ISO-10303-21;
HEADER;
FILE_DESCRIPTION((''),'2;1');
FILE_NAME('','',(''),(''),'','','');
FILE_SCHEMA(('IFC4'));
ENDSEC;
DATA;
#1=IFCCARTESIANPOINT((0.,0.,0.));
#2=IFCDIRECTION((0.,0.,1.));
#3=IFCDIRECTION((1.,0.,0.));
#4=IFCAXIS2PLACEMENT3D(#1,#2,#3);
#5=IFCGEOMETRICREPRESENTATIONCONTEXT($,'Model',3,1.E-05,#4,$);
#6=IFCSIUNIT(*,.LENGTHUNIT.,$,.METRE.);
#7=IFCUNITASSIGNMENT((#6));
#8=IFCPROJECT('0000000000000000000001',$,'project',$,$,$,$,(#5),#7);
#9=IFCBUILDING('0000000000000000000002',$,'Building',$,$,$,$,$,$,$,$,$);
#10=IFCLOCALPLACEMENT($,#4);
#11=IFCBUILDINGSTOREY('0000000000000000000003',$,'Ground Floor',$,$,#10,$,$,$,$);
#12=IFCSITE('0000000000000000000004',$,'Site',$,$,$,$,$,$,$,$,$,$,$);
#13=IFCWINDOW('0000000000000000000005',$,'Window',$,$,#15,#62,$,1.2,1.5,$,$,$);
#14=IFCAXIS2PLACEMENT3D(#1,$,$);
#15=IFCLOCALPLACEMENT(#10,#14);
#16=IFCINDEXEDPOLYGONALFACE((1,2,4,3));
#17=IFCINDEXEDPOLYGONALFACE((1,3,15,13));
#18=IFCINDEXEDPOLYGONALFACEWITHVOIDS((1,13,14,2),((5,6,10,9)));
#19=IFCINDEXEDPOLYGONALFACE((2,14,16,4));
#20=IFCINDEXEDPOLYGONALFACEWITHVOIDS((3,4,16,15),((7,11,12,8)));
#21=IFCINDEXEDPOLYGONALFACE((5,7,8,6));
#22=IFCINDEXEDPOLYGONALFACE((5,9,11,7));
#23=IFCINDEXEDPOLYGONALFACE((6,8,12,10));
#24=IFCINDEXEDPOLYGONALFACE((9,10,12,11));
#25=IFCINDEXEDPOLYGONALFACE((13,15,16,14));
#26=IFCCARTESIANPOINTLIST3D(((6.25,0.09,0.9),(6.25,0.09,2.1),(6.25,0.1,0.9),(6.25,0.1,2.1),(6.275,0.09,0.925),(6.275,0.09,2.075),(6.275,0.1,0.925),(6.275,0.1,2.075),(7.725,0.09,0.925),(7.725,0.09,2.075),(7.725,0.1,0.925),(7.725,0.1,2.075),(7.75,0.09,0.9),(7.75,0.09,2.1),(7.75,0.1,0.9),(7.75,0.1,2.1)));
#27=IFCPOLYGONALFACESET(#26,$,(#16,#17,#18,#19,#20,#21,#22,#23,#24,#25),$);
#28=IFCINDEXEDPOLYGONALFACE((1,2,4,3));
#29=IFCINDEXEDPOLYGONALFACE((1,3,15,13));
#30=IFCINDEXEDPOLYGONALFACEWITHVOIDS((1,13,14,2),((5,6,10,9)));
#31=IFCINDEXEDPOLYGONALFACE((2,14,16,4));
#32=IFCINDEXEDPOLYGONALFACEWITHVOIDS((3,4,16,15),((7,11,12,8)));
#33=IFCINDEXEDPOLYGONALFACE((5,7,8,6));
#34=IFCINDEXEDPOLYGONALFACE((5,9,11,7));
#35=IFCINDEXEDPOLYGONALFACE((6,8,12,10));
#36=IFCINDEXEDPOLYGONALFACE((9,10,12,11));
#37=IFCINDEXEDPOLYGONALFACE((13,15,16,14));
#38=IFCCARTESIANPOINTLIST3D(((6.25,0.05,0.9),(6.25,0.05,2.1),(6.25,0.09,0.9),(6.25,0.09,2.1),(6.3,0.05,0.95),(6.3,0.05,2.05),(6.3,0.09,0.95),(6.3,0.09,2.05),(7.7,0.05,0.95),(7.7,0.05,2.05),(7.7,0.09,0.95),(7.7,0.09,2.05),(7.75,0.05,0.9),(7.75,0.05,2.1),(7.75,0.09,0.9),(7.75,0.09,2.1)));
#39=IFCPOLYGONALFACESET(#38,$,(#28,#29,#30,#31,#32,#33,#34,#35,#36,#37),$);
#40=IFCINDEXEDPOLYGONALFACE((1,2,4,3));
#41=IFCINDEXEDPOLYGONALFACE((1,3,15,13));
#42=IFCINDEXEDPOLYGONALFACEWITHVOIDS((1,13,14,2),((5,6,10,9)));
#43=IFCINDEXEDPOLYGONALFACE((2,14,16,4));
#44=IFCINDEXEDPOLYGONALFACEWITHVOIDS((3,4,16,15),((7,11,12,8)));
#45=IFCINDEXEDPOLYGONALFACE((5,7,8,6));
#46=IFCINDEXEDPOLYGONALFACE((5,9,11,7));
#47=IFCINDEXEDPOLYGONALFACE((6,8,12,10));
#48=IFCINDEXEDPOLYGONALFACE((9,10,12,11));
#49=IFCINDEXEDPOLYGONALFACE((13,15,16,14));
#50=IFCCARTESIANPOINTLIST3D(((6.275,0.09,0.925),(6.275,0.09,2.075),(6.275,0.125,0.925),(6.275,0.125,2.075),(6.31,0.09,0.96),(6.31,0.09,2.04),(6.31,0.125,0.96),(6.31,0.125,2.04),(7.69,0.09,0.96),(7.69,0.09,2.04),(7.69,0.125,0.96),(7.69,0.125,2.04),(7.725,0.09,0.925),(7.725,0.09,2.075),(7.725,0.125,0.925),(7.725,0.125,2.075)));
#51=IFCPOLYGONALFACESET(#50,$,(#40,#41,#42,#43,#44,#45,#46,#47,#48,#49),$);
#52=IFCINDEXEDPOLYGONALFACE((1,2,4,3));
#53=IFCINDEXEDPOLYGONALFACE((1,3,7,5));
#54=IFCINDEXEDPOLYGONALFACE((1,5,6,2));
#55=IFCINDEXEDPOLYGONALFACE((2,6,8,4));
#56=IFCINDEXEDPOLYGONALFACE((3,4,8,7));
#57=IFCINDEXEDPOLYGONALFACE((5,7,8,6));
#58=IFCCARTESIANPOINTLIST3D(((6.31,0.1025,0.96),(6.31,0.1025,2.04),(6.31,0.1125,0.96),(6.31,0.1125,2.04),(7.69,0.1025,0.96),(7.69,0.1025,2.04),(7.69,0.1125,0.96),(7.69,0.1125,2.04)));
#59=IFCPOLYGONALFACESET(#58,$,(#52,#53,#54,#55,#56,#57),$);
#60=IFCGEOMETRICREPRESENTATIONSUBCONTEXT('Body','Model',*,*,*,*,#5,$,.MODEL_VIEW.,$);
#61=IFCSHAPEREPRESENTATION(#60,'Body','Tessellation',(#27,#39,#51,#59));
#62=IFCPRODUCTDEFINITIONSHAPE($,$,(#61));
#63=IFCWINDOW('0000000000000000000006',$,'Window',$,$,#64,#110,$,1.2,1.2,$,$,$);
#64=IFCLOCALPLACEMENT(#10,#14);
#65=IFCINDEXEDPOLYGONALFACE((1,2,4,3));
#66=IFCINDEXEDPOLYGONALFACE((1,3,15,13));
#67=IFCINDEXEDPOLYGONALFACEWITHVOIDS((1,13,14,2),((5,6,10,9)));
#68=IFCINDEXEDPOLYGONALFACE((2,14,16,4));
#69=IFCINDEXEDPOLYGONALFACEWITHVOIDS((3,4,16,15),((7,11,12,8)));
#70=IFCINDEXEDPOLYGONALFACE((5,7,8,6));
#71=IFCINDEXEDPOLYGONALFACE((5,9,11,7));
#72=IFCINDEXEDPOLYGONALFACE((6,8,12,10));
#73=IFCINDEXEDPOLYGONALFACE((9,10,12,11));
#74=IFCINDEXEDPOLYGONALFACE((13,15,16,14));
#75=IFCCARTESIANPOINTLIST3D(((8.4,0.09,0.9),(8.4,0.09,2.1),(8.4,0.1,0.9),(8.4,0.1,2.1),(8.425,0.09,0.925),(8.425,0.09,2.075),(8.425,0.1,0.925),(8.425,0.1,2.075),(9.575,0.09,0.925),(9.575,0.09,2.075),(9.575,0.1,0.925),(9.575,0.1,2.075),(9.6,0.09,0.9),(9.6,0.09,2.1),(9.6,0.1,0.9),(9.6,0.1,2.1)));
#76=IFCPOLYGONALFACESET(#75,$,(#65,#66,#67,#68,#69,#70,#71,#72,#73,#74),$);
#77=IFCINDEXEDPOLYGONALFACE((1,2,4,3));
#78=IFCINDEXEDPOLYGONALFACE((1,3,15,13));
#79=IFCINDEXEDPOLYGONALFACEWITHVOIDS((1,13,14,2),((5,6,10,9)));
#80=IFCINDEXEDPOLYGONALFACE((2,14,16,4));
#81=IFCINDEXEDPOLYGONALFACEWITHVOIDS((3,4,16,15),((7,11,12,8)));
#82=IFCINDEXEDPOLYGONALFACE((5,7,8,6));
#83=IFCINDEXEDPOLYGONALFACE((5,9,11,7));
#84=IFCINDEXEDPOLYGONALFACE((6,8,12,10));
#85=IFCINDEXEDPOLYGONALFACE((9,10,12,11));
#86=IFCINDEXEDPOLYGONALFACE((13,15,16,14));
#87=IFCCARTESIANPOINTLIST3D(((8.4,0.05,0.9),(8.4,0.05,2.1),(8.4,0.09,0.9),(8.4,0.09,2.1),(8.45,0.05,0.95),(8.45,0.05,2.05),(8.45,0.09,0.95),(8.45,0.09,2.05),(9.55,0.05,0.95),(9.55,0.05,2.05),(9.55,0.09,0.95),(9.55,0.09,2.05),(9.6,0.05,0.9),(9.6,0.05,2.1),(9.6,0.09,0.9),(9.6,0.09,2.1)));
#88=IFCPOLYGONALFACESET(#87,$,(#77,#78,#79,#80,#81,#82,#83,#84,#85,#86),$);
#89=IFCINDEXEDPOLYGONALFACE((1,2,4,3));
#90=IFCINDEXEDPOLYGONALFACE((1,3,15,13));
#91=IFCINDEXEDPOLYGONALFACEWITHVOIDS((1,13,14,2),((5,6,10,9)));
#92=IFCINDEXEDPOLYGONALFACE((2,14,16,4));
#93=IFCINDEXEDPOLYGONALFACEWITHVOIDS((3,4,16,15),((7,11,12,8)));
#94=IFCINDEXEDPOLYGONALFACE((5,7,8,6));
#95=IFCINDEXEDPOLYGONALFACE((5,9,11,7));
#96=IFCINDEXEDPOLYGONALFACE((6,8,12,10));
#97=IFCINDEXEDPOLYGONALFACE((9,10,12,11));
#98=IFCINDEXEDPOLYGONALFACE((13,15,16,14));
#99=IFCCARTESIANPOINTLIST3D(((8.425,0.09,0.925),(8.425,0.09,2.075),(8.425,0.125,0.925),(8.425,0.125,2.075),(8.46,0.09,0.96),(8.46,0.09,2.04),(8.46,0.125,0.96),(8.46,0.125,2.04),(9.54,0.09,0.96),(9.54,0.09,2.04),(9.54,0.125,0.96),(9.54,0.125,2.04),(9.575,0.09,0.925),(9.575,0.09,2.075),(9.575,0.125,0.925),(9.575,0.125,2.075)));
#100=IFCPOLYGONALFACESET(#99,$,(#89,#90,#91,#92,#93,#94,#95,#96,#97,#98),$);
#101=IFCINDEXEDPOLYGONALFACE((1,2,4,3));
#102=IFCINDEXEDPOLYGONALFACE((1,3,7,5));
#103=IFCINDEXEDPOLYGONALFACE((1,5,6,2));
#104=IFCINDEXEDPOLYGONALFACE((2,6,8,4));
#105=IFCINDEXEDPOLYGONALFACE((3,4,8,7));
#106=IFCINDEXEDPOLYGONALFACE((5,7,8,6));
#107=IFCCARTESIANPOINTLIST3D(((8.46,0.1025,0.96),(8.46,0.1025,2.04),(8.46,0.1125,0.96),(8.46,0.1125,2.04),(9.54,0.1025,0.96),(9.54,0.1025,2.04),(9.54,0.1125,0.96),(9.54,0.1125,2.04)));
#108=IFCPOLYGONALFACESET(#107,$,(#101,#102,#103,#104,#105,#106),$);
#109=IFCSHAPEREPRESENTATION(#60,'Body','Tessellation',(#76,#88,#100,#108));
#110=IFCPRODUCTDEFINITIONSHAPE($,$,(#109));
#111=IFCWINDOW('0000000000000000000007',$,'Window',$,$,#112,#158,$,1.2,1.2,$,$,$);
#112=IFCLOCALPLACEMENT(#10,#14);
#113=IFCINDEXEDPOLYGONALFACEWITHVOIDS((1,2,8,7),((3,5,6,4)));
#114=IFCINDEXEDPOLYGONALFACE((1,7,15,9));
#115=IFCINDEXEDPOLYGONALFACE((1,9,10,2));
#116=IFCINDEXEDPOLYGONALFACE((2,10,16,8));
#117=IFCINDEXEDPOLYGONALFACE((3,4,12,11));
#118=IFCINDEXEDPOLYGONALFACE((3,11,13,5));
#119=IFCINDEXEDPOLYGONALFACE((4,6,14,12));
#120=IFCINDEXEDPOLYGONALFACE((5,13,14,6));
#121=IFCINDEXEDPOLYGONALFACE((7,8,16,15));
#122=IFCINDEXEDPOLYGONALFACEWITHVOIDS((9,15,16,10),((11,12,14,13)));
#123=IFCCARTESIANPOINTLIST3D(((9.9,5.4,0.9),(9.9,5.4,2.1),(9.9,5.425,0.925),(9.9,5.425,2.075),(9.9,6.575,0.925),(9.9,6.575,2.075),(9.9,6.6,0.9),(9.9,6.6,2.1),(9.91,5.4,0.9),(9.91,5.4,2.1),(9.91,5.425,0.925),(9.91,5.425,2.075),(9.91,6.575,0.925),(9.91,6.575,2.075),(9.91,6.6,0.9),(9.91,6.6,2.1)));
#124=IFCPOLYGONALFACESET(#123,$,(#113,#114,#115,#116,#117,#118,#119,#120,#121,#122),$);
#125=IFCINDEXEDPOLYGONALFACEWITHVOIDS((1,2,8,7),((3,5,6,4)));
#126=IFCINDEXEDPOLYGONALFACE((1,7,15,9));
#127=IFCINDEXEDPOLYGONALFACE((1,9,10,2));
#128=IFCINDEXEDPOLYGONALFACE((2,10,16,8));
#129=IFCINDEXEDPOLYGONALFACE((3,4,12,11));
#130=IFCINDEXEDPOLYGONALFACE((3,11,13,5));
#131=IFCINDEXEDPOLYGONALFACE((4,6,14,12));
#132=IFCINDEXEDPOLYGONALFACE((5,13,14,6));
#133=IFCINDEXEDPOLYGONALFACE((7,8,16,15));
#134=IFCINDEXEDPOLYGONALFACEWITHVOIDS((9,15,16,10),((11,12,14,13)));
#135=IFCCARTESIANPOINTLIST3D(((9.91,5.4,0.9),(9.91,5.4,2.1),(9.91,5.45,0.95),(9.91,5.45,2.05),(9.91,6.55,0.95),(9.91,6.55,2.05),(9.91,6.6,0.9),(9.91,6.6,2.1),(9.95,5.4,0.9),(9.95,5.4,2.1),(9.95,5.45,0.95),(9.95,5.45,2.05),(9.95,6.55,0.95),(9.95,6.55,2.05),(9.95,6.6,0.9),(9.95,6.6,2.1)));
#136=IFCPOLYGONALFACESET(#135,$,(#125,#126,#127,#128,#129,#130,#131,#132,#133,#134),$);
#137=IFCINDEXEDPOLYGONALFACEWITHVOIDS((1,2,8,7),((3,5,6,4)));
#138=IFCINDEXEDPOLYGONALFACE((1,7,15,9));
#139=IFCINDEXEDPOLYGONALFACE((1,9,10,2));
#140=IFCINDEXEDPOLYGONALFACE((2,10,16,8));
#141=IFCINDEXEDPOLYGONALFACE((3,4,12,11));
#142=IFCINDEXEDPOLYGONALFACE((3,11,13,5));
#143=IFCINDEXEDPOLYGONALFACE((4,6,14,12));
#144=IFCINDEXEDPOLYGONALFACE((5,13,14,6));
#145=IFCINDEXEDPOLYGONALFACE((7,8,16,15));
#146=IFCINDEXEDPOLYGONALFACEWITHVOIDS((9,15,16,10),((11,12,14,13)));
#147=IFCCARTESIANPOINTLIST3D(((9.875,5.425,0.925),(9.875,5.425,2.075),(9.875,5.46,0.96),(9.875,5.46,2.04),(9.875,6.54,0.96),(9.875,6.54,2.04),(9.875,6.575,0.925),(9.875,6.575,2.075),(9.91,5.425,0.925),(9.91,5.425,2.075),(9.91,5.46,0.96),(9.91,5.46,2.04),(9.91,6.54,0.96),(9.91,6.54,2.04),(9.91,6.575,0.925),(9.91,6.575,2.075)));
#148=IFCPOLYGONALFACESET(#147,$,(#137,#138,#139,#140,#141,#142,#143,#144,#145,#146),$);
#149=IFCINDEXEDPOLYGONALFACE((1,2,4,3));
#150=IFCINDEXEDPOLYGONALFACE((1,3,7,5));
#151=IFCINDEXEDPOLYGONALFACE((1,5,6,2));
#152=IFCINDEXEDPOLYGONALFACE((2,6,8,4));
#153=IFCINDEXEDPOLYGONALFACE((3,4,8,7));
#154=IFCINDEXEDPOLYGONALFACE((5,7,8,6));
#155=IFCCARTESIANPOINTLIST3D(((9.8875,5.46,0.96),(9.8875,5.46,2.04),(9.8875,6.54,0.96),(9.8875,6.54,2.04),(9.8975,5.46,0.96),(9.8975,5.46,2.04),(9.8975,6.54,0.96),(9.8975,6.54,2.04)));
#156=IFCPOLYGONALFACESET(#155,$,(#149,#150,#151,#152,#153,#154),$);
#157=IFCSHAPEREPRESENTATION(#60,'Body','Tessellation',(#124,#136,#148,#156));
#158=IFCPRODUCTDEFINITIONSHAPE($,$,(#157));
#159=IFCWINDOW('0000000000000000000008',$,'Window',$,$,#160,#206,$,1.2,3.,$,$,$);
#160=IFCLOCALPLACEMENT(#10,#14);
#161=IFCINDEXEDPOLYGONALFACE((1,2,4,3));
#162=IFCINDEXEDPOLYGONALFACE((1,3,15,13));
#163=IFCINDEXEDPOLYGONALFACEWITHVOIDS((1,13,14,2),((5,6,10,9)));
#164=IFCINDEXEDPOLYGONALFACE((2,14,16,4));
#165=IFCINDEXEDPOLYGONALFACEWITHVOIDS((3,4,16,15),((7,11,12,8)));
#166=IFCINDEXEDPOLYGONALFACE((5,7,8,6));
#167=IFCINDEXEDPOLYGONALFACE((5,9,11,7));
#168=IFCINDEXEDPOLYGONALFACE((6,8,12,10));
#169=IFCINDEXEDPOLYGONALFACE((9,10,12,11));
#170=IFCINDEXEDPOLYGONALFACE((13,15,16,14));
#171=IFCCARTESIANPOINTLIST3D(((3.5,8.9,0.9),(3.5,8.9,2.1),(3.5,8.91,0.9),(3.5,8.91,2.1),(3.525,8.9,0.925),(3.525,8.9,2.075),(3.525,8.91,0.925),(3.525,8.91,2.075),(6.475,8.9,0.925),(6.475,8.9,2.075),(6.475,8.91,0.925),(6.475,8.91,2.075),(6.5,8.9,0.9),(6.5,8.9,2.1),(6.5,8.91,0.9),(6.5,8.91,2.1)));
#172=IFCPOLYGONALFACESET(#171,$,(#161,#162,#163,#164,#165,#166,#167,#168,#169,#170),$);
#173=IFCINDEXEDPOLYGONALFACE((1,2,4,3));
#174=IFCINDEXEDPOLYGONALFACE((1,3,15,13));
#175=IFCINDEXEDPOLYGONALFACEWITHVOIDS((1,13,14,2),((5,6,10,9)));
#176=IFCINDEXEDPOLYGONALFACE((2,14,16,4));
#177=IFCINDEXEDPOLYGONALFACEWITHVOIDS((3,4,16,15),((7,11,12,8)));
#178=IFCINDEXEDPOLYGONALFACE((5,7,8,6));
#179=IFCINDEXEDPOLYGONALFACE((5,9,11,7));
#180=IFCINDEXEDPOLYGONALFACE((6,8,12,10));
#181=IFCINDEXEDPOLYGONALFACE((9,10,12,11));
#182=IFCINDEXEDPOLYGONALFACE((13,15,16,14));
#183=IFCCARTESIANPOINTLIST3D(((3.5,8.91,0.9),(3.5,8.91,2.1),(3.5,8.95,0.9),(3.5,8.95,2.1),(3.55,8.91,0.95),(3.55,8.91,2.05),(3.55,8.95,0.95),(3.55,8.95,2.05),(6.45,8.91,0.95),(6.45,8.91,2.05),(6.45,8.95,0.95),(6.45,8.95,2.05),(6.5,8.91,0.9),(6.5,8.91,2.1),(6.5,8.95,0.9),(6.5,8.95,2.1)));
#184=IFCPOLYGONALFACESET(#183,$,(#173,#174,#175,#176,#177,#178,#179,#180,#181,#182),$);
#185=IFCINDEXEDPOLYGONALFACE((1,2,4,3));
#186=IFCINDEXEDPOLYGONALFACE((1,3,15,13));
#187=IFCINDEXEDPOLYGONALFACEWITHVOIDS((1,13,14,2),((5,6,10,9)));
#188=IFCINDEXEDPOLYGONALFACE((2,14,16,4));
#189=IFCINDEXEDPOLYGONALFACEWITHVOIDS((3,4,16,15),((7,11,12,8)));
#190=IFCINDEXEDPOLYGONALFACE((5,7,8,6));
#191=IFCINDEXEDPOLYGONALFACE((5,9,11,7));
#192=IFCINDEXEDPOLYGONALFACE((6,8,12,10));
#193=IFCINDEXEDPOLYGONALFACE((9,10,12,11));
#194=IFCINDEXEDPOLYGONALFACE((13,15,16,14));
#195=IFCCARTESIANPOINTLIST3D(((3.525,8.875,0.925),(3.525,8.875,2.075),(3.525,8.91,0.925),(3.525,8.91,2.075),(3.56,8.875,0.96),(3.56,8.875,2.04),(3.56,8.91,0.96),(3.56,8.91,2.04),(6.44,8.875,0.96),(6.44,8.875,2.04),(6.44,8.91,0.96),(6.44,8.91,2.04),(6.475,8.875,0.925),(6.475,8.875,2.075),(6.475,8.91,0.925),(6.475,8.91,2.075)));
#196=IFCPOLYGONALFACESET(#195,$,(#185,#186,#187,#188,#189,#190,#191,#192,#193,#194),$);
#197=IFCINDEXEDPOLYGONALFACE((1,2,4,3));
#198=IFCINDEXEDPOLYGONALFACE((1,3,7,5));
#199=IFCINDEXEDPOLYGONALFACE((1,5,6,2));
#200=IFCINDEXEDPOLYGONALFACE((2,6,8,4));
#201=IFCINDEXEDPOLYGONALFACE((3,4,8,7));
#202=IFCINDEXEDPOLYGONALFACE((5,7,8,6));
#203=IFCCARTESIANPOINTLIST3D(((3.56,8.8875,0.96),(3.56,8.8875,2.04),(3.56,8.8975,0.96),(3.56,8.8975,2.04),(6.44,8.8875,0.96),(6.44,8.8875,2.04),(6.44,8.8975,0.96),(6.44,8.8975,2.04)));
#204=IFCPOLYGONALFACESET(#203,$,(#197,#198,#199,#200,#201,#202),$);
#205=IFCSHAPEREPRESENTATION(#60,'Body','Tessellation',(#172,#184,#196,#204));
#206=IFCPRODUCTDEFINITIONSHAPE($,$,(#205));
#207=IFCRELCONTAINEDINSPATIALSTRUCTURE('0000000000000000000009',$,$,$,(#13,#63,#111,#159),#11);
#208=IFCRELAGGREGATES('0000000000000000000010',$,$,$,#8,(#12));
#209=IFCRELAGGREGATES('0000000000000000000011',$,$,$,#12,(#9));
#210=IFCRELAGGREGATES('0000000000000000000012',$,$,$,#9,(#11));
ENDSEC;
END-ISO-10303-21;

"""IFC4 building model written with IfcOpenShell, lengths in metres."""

from ifc_helpers import new_model, si_unit, frame, origin_with_axes, place, context, subcontext, project, spatial, line, indexed_curve, outline, extrude, element, save


model = new_model("IFC4")

# Units and contexts
model_context = context("Model", 3, precision=1e-05, world=origin_with_axes())
body_context = subcontext(model_context, "Body", "Model", "MODEL_VIEW")
ifc_project = project(units=[si_unit("LENGTHUNIT", "METRE")], contexts=[model_context])

# Site, building, storey
site = spatial("IfcSite", under=ifc_project, Name="Site")
building = spatial("IfcBuilding", under=site, Name="Building")
storey_placement = place(None, origin_with_axes())
storey = spatial("IfcBuildingStorey", under=building, at=storey_placement, Name="Ground Floor")

# Windows
window_1_placement = place(storey_placement, frame((6.25, 0.0, 0.9), z_axis=(0.0, 0.0, 1.0), x_axis=(1.0, 0.0, 0.0)))
element("IfcWindow", 1, at=window_1_placement, inside=storey, Name="Window", OverallHeight=1.2, OverallWidth=1.5, context=body_context, shape_type="SweptSolid", body=[
    extrude(outline(indexed_curve([(0.0, 0.0), (1.5, 0.0), (1.5, 1.2), (0.0, 1.2)], segments=[line(1, 2, 3, 4, 1)]), holes=[indexed_curve([(0.025, 0.025), (1.475, 0.025), (1.475, 1.175), (0.025, 1.175)], segments=[line(1, 2, 3, 4, 1)])]), frame((0.0, 0.09, 0.0), z_axis=(0.0, -1.0, 0.0), x_axis=(1.0, 0.0, 0.0)), (0.0, 0.0, -1.0), 0.01),
    extrude(outline(indexed_curve([(0.0, 0.0), (1.5, 0.0), (1.5, 1.2), (0.0, 1.2)], segments=[line(1, 2, 3, 4, 1)]), holes=[indexed_curve([(0.05, 0.05), (1.45, 0.05), (1.45, 1.15), (0.05, 1.15)], segments=[line(1, 2, 3, 4, 1)])]), frame((0.0, 0.05, 0.0), z_axis=(0.0, -1.0, 0.0), x_axis=(1.0, 0.0, 0.0)), (0.0, 0.0, -1.0), 0.04),
    extrude(outline(indexed_curve([(0.0, 0.0), (1.45, 0.0), (1.45, 1.15), (0.0, 1.15)], segments=[line(1, 2, 3, 4, 1)]), holes=[indexed_curve([(0.035, 0.035), (1.415, 0.035), (1.415, 1.115), (0.035, 1.115)], segments=[line(1, 2, 3, 4, 1)])]), frame((0.025, 0.09, 0.025), z_axis=(0.0, -1.0, 0.0), x_axis=(1.0, 0.0, 0.0)), (0.0, 0.0, -1.0), 0.035),
    extrude(outline(indexed_curve([(0.035, 0.035), (1.415, 0.035), (1.415, 1.115), (0.035, 1.115)], segments=[line(1, 2, 3, 4, 1)])), frame((0.025, 0.1025, 0.025), z_axis=(0.0, -1.0, 0.0), x_axis=(1.0, 0.0, 0.0)), (0.0, 0.0, -1.0), 0.01),
])
for number, where, z_axis, x_axis, name in (
    (2, (8.4, 0.0, 0.9), (0.0, 0.0, 1.0), (1.0, 0.0, 0.0), "Window"),
    (3, (10.0, 5.4, 0.9), (0.0, 0.0, 1.0), (0.0, 1.0, 0.0), "Window"),
):
    element("IfcWindow", number, at=place(storey_placement, frame(where, z_axis=z_axis, x_axis=x_axis)), inside=storey, Name=name, OverallHeight=1.2, OverallWidth=1.2, context=body_context, shape_type="SweptSolid", body=[
        extrude(outline(indexed_curve([(0.0, 0.0), (1.2, 0.0), (1.2, 1.2), (0.0, 1.2)], segments=[line(1, 2, 3, 4, 1)]), holes=[indexed_curve([(0.025, 0.025), (1.175, 0.025), (1.175, 1.175), (0.025, 1.175)], segments=[line(1, 2, 3, 4, 1)])]), frame((0.0, 0.09, 0.0), z_axis=(0.0, -1.0, 0.0), x_axis=(1.0, 0.0, 0.0)), (0.0, 0.0, -1.0), 0.01),
        extrude(outline(indexed_curve([(0.0, 0.0), (1.2, 0.0), (1.2, 1.2), (0.0, 1.2)], segments=[line(1, 2, 3, 4, 1)]), holes=[indexed_curve([(0.05, 0.05), (1.15, 0.05), (1.15, 1.15), (0.05, 1.15)], segments=[line(1, 2, 3, 4, 1)])]), frame((0.0, 0.05, 0.0), z_axis=(0.0, -1.0, 0.0), x_axis=(1.0, 0.0, 0.0)), (0.0, 0.0, -1.0), 0.04),
        extrude(outline(indexed_curve([(0.0, 0.0), (1.15, 0.0), (1.15, 1.15), (0.0, 1.15)], segments=[line(1, 2, 3, 4, 1)]), holes=[indexed_curve([(0.035, 0.035), (1.115, 0.035), (1.115, 1.115), (0.035, 1.115)], segments=[line(1, 2, 3, 4, 1)])]), frame((0.025, 0.09, 0.025), z_axis=(0.0, -1.0, 0.0), x_axis=(1.0, 0.0, 0.0)), (0.0, 0.0, -1.0), 0.035),
        extrude(outline(indexed_curve([(0.035, 0.035), (1.115, 0.035), (1.115, 1.115), (0.035, 1.115)], segments=[line(1, 2, 3, 4, 1)])), frame((0.025, 0.1025, 0.025), z_axis=(0.0, -1.0, 0.0), x_axis=(1.0, 0.0, 0.0)), (0.0, 0.0, -1.0), 0.01),
    ])
window_2_placement = place(storey_placement, frame((6.5, 9.0, 0.9), z_axis=(0.0, 0.0, 1.0), x_axis=(-1.0, 0.0, 0.0)))
element("IfcWindow", 4, at=window_2_placement, inside=storey, Name="Window", OverallHeight=1.2, OverallWidth=3.0, context=body_context, shape_type="SweptSolid", body=[
    extrude(outline(indexed_curve([(0.0, 0.0), (3.0, 0.0), (3.0, 1.2), (0.0, 1.2)], segments=[line(1, 2, 3, 4, 1)]), holes=[indexed_curve([(0.025, 0.025), (2.975, 0.025), (2.975, 1.175), (0.025, 1.175)], segments=[line(1, 2, 3, 4, 1)])]), frame((0.0, 0.09, 0.0), z_axis=(0.0, -1.0, 0.0), x_axis=(1.0, 0.0, 0.0)), (0.0, 0.0, -1.0), 0.01),
    extrude(outline(indexed_curve([(0.0, 0.0), (3.0, 0.0), (3.0, 1.2), (0.0, 1.2)], segments=[line(1, 2, 3, 4, 1)]), holes=[indexed_curve([(0.05, 0.05), (2.95, 0.05), (2.95, 1.15), (0.05, 1.15)], segments=[line(1, 2, 3, 4, 1)])]), frame((0.0, 0.05, 0.0), z_axis=(0.0, -1.0, 0.0), x_axis=(1.0, 0.0, 0.0)), (0.0, 0.0, -1.0), 0.04),
    extrude(outline(indexed_curve([(0.0, 0.0), (2.95, 0.0), (2.95, 1.15), (0.0, 1.15)], segments=[line(1, 2, 3, 4, 1)]), holes=[indexed_curve([(0.035, 0.035), (2.915, 0.035), (2.915, 1.115), (0.035, 1.115)], segments=[line(1, 2, 3, 4, 1)])]), frame((0.025, 0.09, 0.025), z_axis=(0.0, -1.0, 0.0), x_axis=(1.0, 0.0, 0.0)), (0.0, 0.0, -1.0), 0.035),
    extrude(outline(indexed_curve([(0.035, 0.035), (2.915, 0.035), (2.915, 1.115), (0.035, 1.115)], segments=[line(1, 2, 3, 4, 1)])), frame((0.025, 0.1025, 0.025), z_axis=(0.0, -1.0, 0.0), x_axis=(1.0, 0.0, 0.0)), (0.0, 0.0, -1.0), 0.01),
])

save(model, "model.ifc")
